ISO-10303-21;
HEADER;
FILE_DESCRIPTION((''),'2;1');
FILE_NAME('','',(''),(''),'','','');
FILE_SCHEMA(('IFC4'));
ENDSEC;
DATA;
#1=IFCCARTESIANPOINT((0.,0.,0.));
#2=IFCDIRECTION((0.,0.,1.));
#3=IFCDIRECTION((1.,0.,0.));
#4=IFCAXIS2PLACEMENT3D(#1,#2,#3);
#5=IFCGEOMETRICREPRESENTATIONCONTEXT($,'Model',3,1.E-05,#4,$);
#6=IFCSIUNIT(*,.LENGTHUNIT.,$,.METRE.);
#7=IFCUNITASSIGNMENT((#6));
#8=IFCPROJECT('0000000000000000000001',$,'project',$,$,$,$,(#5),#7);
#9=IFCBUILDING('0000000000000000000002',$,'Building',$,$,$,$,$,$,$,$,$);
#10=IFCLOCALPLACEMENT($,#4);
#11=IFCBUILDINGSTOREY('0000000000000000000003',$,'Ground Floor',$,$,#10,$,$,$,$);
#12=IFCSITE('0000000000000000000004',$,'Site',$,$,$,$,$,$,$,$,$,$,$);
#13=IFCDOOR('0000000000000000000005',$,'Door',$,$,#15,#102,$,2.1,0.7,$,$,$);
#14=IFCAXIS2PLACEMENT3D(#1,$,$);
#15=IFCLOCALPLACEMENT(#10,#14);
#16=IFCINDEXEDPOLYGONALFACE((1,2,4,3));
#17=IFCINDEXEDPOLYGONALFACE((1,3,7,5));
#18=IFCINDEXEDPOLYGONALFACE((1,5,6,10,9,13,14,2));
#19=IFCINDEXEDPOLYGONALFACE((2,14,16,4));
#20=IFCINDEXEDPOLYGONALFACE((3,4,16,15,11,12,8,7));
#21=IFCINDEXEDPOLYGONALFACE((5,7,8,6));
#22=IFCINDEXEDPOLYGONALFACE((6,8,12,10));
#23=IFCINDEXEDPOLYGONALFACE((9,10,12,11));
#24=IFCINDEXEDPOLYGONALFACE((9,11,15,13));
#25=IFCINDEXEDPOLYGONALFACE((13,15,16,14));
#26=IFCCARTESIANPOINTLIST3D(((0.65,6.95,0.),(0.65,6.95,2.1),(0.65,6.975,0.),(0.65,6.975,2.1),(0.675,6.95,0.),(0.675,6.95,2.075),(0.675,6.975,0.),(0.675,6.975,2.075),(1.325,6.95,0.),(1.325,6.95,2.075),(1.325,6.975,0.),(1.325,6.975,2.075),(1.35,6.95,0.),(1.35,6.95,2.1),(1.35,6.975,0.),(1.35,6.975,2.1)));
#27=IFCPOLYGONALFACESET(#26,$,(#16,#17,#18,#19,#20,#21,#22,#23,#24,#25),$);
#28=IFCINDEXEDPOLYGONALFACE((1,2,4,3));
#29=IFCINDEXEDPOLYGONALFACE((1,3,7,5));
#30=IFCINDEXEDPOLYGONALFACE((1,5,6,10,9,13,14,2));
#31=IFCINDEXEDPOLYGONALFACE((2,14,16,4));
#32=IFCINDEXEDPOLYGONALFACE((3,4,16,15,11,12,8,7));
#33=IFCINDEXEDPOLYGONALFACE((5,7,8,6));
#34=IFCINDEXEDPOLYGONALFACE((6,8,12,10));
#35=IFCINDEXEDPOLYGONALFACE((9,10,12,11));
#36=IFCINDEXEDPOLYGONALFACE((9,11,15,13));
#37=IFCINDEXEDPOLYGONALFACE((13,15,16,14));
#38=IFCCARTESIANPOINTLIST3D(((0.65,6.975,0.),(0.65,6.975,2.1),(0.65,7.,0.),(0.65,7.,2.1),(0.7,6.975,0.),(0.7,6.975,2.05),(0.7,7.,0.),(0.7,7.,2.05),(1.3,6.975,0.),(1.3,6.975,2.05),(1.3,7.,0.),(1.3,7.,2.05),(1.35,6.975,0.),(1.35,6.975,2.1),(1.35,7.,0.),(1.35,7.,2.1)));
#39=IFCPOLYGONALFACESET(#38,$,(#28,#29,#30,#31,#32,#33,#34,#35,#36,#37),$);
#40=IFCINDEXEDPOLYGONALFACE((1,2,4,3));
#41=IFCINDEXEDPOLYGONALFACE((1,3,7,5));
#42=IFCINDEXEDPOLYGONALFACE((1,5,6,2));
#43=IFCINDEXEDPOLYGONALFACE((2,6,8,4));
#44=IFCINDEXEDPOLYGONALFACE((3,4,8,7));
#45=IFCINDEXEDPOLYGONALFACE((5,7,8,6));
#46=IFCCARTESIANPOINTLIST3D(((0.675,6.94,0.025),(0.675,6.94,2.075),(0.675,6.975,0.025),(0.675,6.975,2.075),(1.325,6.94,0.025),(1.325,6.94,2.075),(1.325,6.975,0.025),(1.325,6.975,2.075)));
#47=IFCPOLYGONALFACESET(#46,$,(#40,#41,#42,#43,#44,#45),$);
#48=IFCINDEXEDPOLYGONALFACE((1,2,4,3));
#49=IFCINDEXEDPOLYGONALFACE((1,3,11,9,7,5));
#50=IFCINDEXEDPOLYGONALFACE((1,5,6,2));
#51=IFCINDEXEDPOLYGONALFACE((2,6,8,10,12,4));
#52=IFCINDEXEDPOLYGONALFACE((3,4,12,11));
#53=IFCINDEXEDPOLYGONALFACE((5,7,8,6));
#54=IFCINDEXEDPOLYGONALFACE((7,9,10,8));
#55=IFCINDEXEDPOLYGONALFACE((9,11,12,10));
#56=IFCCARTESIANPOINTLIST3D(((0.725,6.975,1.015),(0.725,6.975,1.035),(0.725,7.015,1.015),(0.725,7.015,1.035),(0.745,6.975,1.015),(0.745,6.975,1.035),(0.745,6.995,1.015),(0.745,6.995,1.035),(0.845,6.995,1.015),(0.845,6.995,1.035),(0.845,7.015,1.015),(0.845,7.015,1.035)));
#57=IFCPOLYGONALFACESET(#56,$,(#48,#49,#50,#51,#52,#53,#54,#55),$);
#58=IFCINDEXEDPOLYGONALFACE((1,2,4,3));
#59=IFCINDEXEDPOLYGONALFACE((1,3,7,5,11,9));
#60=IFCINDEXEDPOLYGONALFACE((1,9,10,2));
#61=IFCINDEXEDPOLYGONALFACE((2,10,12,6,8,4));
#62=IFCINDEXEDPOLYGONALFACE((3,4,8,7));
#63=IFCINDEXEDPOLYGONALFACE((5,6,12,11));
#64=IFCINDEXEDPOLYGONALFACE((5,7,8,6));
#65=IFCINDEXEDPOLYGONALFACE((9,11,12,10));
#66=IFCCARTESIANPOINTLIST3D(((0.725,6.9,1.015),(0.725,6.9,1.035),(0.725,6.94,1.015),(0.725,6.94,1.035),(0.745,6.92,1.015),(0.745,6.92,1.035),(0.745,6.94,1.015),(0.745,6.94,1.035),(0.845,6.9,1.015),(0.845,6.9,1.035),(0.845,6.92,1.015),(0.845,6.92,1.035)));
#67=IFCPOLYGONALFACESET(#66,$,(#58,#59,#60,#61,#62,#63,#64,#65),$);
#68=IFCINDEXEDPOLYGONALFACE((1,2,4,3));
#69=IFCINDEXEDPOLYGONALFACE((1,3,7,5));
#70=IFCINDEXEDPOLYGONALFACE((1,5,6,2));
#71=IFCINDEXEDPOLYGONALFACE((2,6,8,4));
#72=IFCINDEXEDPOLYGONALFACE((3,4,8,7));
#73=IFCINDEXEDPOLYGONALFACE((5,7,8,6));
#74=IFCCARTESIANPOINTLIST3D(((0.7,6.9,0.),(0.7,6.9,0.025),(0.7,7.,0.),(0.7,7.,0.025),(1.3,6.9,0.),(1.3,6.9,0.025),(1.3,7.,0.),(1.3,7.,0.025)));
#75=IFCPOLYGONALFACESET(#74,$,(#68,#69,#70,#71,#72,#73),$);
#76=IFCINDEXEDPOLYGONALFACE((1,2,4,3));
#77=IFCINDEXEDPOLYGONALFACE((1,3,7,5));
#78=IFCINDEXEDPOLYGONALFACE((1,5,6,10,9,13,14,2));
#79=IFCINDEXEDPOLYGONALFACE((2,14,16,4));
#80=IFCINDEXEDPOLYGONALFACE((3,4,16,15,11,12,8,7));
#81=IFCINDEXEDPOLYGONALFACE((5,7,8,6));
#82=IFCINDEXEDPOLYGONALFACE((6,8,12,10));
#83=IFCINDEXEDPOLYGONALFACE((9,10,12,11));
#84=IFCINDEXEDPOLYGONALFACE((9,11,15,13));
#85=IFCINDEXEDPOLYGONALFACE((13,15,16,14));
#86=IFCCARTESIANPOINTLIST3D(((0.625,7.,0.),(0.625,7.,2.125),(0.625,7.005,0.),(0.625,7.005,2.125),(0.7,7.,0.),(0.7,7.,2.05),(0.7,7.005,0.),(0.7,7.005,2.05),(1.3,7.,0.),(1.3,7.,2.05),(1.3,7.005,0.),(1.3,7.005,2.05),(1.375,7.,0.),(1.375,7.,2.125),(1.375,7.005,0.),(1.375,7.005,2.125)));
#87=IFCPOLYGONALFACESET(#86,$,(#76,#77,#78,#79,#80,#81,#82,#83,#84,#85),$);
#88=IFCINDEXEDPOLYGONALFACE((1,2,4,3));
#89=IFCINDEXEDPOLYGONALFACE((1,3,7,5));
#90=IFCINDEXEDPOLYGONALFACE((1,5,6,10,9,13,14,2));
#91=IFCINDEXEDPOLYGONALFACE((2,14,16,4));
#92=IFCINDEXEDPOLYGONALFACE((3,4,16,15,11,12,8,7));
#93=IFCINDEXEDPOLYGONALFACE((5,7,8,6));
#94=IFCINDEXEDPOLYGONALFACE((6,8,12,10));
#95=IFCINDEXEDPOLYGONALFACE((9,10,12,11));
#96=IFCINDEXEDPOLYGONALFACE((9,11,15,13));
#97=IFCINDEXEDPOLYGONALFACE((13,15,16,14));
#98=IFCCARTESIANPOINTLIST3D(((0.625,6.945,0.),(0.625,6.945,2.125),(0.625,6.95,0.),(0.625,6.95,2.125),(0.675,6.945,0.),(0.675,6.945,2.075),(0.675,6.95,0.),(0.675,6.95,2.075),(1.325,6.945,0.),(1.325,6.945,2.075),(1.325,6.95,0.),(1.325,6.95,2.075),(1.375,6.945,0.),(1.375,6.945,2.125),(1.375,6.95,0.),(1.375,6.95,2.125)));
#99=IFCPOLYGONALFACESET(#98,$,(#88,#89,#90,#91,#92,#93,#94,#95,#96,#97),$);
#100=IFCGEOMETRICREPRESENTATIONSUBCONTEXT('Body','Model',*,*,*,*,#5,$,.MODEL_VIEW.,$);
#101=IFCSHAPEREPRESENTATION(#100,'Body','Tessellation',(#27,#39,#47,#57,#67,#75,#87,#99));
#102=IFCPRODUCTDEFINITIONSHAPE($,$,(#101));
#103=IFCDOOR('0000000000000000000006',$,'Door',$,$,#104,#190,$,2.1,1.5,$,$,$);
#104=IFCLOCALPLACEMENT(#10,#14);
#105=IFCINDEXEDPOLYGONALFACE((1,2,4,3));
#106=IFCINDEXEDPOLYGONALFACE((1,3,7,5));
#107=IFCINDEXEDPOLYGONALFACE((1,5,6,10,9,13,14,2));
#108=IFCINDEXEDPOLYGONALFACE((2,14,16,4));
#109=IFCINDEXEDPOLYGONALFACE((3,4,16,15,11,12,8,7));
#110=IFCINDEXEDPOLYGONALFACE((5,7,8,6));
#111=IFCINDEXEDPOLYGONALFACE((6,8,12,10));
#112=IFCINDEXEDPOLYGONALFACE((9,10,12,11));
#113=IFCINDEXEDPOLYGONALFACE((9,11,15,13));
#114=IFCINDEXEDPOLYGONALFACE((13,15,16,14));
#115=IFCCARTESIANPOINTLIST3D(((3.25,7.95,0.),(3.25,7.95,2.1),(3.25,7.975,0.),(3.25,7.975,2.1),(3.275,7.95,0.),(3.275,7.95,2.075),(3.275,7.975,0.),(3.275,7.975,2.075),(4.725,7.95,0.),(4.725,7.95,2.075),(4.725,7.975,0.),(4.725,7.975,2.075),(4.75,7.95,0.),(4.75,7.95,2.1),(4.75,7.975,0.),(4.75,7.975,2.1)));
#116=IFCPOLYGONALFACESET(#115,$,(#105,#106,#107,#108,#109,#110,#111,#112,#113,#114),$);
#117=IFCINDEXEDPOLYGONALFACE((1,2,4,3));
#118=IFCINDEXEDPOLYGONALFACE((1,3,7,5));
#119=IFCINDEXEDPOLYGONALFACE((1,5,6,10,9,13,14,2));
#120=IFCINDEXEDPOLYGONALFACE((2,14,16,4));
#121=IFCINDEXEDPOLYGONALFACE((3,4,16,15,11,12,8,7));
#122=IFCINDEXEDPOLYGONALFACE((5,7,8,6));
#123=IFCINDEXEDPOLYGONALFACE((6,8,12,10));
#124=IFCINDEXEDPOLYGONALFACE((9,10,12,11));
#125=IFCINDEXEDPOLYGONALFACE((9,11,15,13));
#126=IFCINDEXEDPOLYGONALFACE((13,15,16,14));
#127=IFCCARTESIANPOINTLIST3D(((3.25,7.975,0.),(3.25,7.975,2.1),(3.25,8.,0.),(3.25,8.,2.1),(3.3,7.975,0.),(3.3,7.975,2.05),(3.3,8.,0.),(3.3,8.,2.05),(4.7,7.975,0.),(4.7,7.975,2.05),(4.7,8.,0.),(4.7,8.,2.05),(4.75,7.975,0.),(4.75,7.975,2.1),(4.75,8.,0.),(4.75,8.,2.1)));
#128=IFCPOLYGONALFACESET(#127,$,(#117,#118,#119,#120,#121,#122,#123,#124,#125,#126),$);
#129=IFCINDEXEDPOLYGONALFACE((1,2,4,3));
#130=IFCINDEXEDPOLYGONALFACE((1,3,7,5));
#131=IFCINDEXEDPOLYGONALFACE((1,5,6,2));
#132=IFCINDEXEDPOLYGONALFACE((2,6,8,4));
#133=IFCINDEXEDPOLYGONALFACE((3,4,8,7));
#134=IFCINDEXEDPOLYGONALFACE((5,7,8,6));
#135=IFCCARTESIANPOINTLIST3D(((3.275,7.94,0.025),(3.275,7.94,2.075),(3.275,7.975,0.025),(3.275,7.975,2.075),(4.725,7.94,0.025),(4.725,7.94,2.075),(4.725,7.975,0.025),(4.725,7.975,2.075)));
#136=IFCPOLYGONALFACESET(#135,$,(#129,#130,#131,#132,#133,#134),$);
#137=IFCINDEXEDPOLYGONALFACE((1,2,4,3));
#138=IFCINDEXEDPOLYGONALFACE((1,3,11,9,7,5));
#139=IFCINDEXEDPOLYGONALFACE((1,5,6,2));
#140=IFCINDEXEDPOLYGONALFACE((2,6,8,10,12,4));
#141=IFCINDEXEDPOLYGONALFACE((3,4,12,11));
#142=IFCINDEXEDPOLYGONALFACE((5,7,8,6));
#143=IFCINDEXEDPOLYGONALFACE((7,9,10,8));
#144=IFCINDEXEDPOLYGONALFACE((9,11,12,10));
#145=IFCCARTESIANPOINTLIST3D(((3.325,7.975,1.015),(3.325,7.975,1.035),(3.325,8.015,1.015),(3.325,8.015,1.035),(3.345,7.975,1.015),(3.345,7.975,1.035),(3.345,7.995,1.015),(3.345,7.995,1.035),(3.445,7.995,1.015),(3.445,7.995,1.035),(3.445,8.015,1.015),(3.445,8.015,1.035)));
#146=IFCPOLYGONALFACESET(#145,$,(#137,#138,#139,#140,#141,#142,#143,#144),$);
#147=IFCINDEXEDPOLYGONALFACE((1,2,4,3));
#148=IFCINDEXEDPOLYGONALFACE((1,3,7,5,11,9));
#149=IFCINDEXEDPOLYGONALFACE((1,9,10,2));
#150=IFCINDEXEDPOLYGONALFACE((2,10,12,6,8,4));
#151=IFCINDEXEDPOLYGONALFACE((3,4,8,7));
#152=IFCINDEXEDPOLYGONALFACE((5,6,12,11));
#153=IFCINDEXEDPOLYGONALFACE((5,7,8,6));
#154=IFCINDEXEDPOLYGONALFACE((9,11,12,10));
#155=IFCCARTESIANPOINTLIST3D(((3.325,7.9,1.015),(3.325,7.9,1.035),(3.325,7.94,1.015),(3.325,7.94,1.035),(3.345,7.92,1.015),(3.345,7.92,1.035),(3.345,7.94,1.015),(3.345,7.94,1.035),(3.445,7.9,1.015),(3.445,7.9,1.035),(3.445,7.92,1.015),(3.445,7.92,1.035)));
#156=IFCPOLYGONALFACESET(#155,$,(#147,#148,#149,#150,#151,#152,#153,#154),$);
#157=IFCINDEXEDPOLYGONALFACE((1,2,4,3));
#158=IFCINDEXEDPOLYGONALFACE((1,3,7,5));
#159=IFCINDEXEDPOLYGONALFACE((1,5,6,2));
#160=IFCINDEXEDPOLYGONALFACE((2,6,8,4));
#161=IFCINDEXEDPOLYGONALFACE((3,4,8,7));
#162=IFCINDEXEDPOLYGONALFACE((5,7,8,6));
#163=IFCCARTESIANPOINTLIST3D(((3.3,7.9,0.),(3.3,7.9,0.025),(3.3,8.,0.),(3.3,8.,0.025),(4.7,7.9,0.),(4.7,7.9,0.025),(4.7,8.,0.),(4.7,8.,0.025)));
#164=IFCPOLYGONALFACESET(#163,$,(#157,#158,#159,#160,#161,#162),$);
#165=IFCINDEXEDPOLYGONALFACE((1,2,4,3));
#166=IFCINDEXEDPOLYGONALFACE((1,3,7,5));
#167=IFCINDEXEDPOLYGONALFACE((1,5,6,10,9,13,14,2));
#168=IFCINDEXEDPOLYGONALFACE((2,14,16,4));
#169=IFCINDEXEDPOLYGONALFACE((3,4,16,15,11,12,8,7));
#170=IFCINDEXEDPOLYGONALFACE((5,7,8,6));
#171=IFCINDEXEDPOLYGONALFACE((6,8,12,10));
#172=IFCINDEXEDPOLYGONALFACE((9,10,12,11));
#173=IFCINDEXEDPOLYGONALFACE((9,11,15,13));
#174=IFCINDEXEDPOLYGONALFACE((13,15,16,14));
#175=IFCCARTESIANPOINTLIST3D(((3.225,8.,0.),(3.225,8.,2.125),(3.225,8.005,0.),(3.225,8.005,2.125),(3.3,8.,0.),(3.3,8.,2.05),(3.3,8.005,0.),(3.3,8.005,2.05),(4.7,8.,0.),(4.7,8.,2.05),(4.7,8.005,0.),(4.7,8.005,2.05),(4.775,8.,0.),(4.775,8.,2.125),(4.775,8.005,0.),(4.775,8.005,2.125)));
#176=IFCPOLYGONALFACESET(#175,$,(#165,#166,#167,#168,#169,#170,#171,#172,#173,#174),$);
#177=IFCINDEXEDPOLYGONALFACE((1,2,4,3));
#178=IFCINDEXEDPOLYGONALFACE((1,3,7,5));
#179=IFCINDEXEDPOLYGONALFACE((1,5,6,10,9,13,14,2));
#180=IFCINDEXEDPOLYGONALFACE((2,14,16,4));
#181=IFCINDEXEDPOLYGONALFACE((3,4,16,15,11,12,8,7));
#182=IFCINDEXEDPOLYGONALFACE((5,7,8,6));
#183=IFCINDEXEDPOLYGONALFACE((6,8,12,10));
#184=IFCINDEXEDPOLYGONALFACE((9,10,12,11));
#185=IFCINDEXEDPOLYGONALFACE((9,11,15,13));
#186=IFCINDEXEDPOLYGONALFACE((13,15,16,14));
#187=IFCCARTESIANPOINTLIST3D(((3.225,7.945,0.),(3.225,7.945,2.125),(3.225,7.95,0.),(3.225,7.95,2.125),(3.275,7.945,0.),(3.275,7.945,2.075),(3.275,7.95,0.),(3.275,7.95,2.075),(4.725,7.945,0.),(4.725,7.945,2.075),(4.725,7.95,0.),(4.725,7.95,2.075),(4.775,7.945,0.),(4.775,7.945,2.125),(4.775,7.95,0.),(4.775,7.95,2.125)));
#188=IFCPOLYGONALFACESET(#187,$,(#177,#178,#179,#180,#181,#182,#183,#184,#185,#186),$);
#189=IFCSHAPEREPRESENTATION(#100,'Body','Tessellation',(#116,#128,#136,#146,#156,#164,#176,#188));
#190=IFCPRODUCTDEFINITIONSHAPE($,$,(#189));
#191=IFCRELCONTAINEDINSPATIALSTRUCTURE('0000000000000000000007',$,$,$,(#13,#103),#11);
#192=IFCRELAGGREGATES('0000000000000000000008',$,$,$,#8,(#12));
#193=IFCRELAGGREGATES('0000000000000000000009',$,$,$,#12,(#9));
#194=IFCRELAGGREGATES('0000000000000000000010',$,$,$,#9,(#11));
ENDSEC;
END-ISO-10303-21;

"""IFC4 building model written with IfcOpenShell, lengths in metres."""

from ifc_helpers import new_model, si_unit, frame, origin_with_axes, place, context, subcontext, project, spatial, line, indexed_curve, outline, extrude, element, save


model = new_model("IFC4")

# Units and contexts
model_context = context("Model", 3, precision=1e-05, world=origin_with_axes())
body_context = subcontext(model_context, "Body", "Model", "MODEL_VIEW")
ifc_project = project(units=[si_unit("LENGTHUNIT", "METRE")], contexts=[model_context])

# Site, building, storey
site = spatial("IfcSite", under=ifc_project, Name="Site")
building = spatial("IfcBuilding", under=site, Name="Building")
storey_placement = place(None, origin_with_axes())
storey = spatial("IfcBuildingStorey", under=building, at=storey_placement, Name="Ground Floor")

# Doors
door_1_placement = place(storey_placement, frame((1.35, 7.0, 0.0), z_axis=(0.0, 0.0, 1.0), x_axis=(-1.0, 0.0, 0.0)))
element("IfcDoor", 1, at=door_1_placement, inside=storey, Name="Door", OverallHeight=2.1, OverallWidth=0.7, context=body_context, shape_type="SweptSolid", body=[
    extrude(outline(indexed_curve([(0.0, 0.0), (0.0, 2.1), (0.7, 2.1), (0.7, 0.0), (0.675, 0.0), (0.675, 2.075), (0.025, 2.075), (0.025, 0.0)], segments=[line(1, 2, 3, 4, 5, 6, 7, 8, 1)])), frame((0.0, 0.025, 0.0), z_axis=(0.0, -1.0, 0.0), x_axis=(1.0, 0.0, 0.0)), (0.0, 0.0, -1.0), 0.025),
    extrude(outline(indexed_curve([(0.0, 0.0), (0.0, 2.1), (0.7, 2.1), (0.7, 0.0), (0.65, 0.0), (0.65, 2.05), (0.05, 2.05), (0.05, 0.0)], segments=[line(1, 2, 3, 4, 5, 6, 7, 8, 1)])), frame((0.0, 0.0, 0.0), z_axis=(0.0, -1.0, 0.0), x_axis=(1.0, 0.0, 0.0)), (0.0, 0.0, -1.0), 0.025),
    extrude(outline(indexed_curve([(0.0, 0.0), (0.65, 0.0), (0.65, 0.035), (0.0, 0.035)], segments=[line(1, 2, 3, 4, 1)])), frame((0.025, 0.025, 0.025), z_axis=(0.0, 0.0, 1.0), x_axis=(1.0, 0.0, 0.0)), (0.0, 0.0, 1.0), 2.05),
    extrude(outline(indexed_curve([(0.0, 0.0), (0.0, -0.04), (-0.12, -0.04), (-0.12, -0.02), (-0.02, -0.02), (-0.02, 0.0)], segments=[line(1, 2, 3, 4, 5, 6, 1)])), frame((0.625, 0.025, 1.015), z_axis=(0.0, 0.0, 1.0), x_axis=(1.0, 0.0, 0.0)), (0.0, 0.0, 1.0), 0.02),
    extrude(outline(indexed_curve([(0.0, 0.0), (0.0, 0.04), (-0.12, 0.04), (-0.12, 0.02), (-0.02, 0.02), (-0.02, 0.0)], segments=[line(1, 2, 3, 4, 5, 6, 1)])), frame((0.625, 0.06, 1.015), z_axis=(0.0, 0.0, 1.0), x_axis=(1.0, 0.0, 0.0)), (0.0, 0.0, 1.0), 0.02),
    extrude(outline(indexed_curve([(0.0, 0.0), (0.6, 0.0), (0.6, 0.1), (0.0, 0.1)], segments=[line(1, 2, 3, 4, 1)])), frame((0.05, 0.0, 0.0), z_axis=(0.0, 0.0, 1.0), x_axis=(1.0, 0.0, 0.0)), (0.0, 0.0, 1.0), 0.025),
    extrude(outline(indexed_curve([(0.0, 0.0), (0.0, 2.125), (0.75, 2.125), (0.75, 0.0), (0.675, 0.0), (0.675, 2.05), (0.075, 2.05), (0.075, 0.0)], segments=[line(1, 2, 3, 4, 5, 6, 7, 8, 1)])), frame((-0.025, -0.005, 0.0), z_axis=(0.0, -1.0, 0.0), x_axis=(1.0, 0.0, 0.0)), (0.0, 0.0, -1.0), 0.005),
    extrude(outline(indexed_curve([(0.0, 0.0), (0.0, 2.125), (0.75, 2.125), (0.75, 0.0), (0.7, 0.0), (0.7, 2.075), (0.05, 2.075), (0.05, 0.0)], segments=[line(1, 2, 3, 4, 5, 6, 7, 8, 1)])), frame((-0.025, 0.05, 0.0), z_axis=(0.0, -1.0, 0.0), x_axis=(1.0, 0.0, 0.0)), (0.0, 0.0, -1.0), 0.005),
])
door_2_placement = place(storey_placement, frame((4.75, 8.0, 0.0), z_axis=(0.0, 0.0, 1.0), x_axis=(-1.0, 0.0, 0.0)))
element("IfcDoor", 2, at=door_2_placement, inside=storey, Name="Door", OverallHeight=2.1, OverallWidth=1.5, context=body_context, shape_type="SweptSolid", body=[
    extrude(outline(indexed_curve([(0.0, 0.0), (0.0, 2.1), (1.5, 2.1), (1.5, 0.0), (1.475, 0.0), (1.475, 2.075), (0.025, 2.075), (0.025, 0.0)], segments=[line(1, 2, 3, 4, 5, 6, 7, 8, 1)])), frame((0.0, 0.025, 0.0), z_axis=(0.0, -1.0, 0.0), x_axis=(1.0, 0.0, 0.0)), (0.0, 0.0, -1.0), 0.025),
    extrude(outline(indexed_curve([(0.0, 0.0), (0.0, 2.1), (1.5, 2.1), (1.5, 0.0), (1.45, 0.0), (1.45, 2.05), (0.05, 2.05), (0.05, 0.0)], segments=[line(1, 2, 3, 4, 5, 6, 7, 8, 1)])), frame((0.0, 0.0, 0.0), z_axis=(0.0, -1.0, 0.0), x_axis=(1.0, 0.0, 0.0)), (0.0, 0.0, -1.0), 0.025),
    extrude(outline(indexed_curve([(0.0, 0.0), (1.45, 0.0), (1.45, 0.035), (0.0, 0.035)], segments=[line(1, 2, 3, 4, 1)])), frame((0.025, 0.025, 0.025), z_axis=(0.0, 0.0, 1.0), x_axis=(1.0, 0.0, 0.0)), (0.0, 0.0, 1.0), 2.05),
    extrude(outline(indexed_curve([(0.0, 0.0), (0.0, -0.04), (-0.12, -0.04), (-0.12, -0.02), (-0.02, -0.02), (-0.02, 0.0)], segments=[line(1, 2, 3, 4, 5, 6, 1)])), frame((1.425, 0.025, 1.015), z_axis=(0.0, 0.0, 1.0), x_axis=(1.0, 0.0, 0.0)), (0.0, 0.0, 1.0), 0.02),
    extrude(outline(indexed_curve([(0.0, 0.0), (0.0, 0.04), (-0.12, 0.04), (-0.12, 0.02), (-0.02, 0.02), (-0.02, 0.0)], segments=[line(1, 2, 3, 4, 5, 6, 1)])), frame((1.425, 0.06, 1.015), z_axis=(0.0, 0.0, 1.0), x_axis=(1.0, 0.0, 0.0)), (0.0, 0.0, 1.0), 0.02),
    extrude(outline(indexed_curve([(0.0, 0.0), (1.4, 0.0), (1.4, 0.1), (0.0, 0.1)], segments=[line(1, 2, 3, 4, 1)])), frame((0.05, 0.0, 0.0), z_axis=(0.0, 0.0, 1.0), x_axis=(1.0, 0.0, 0.0)), (0.0, 0.0, 1.0), 0.025),
    extrude(outline(indexed_curve([(0.0, 0.0), (0.0, 2.125), (1.55, 2.125), (1.55, 0.0), (1.475, 0.0), (1.475, 2.05), (0.075, 2.05), (0.075, 0.0)], segments=[line(1, 2, 3, 4, 5, 6, 7, 8, 1)])), frame((-0.025, -0.005, 0.0), z_axis=(0.0, -1.0, 0.0), x_axis=(1.0, 0.0, 0.0)), (0.0, 0.0, -1.0), 0.005),
    extrude(outline(indexed_curve([(0.0, 0.0), (0.0, 2.125), (1.55, 2.125), (1.55, 0.0), (1.5, 0.0), (1.5, 2.075), (0.05, 2.075), (0.05, 0.0)], segments=[line(1, 2, 3, 4, 5, 6, 7, 8, 1)])), frame((-0.025, 0.05, 0.0), z_axis=(0.0, -1.0, 0.0), x_axis=(1.0, 0.0, 0.0)), (0.0, 0.0, -1.0), 0.005),
])

save(model, "model.ifc")
